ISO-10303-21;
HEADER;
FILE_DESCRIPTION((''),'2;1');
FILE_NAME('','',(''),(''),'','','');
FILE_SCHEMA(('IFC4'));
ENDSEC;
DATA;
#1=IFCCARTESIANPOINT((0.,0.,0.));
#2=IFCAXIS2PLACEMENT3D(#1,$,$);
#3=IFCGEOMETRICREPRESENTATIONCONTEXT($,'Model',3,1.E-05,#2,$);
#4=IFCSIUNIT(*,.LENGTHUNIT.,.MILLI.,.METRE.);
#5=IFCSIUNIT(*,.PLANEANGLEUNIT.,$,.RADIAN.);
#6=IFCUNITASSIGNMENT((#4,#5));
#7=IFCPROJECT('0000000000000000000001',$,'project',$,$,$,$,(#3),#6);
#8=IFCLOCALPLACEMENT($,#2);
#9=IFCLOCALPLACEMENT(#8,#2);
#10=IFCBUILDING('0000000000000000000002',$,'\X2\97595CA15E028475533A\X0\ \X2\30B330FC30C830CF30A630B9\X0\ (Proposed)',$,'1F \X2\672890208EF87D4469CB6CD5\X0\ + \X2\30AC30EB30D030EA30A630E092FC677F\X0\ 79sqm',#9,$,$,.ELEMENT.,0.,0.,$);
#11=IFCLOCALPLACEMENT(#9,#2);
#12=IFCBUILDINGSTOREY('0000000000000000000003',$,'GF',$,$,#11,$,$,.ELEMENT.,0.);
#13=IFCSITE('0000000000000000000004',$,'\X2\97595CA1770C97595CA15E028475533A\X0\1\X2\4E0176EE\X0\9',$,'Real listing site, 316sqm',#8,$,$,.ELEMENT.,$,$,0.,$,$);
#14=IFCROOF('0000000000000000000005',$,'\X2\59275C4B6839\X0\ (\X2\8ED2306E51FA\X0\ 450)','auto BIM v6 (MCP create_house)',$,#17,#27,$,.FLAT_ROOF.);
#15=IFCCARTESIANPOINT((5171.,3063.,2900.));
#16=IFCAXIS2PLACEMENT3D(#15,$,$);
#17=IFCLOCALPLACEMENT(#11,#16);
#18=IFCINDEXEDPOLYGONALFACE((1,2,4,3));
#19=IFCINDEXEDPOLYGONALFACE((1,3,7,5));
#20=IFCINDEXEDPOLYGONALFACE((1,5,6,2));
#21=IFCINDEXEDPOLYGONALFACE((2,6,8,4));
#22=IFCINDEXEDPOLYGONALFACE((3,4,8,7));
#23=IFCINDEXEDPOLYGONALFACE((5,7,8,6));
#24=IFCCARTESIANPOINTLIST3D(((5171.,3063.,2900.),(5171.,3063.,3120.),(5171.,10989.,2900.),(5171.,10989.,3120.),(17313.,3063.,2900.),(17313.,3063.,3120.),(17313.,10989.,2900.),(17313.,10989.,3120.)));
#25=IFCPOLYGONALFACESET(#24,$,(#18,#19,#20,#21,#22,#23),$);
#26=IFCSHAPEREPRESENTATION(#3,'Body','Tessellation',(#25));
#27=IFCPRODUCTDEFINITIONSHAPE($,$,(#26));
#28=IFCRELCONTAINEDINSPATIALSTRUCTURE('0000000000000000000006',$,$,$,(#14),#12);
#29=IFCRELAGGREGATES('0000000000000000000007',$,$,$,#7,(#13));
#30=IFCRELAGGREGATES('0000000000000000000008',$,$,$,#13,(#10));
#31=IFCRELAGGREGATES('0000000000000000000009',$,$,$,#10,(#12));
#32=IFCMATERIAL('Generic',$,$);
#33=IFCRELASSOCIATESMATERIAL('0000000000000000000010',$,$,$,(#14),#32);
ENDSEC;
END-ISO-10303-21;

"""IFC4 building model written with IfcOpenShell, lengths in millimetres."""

from ifc_helpers import new_model, si_unit, frame, frame_2d, origin, place, context, project, spatial, rectangle, extrude, material, element, save


model = new_model("IFC4")

# Units and contexts
model_context = context("Model", 3, precision=1e-05, world=origin())
ifc_project = project(units=[si_unit("LENGTHUNIT", "METRE", prefix="MILLI"), si_unit("PLANEANGLEUNIT", "RADIAN")], contexts=[model_context])

# Site, building, storey
site_placement = place(None, origin())
site = spatial("IfcSite", under=ifc_project, at=site_placement, Name="静岡県静岡市葵区1丁目9", ObjectType="Real listing site, 316sqm", CompositionType="ELEMENT", RefElevation=0.0)
building_placement = place(site_placement, origin())
building = spatial("IfcBuilding", under=site, at=building_placement, Name="静岡市葵区 コートハウス (Proposed)", ObjectType="1F 木造軸組構法 + ガルバリウム鋼板 79sqm", CompositionType="ELEMENT", ElevationOfRefHeight=0.0, ElevationOfTerrain=0.0)
storey_placement = place(building_placement, origin())
storey = spatial("IfcBuildingStorey", under=building, at=storey_placement, Name="GF", CompositionType="ELEMENT", Elevation=0.0)

# Shared definitions
ifc_material = material(Name="Generic")

# Roof
roof_placement = place(storey_placement, frame((5171.0, 3063.0, 2900.0)))
element("IfcRoof", 1, at=roof_placement, inside=storey, material=ifc_material, Name="大屋根 (軒の出 450)", Description="auto BIM v6 (MCP create_house)", PredefinedType="FLAT_ROOF", context=model_context, shape_type="SweptSolid", body=[
    extrude(rectangle(XDim=12142.0, YDim=7926.0, at=frame_2d((6071.0, 3963.0))), frame((5171.0, 3063.0, 2900.0)), (0.0, 0.0, 1.0), 220.0),
])

save(model, "model.ifc")
